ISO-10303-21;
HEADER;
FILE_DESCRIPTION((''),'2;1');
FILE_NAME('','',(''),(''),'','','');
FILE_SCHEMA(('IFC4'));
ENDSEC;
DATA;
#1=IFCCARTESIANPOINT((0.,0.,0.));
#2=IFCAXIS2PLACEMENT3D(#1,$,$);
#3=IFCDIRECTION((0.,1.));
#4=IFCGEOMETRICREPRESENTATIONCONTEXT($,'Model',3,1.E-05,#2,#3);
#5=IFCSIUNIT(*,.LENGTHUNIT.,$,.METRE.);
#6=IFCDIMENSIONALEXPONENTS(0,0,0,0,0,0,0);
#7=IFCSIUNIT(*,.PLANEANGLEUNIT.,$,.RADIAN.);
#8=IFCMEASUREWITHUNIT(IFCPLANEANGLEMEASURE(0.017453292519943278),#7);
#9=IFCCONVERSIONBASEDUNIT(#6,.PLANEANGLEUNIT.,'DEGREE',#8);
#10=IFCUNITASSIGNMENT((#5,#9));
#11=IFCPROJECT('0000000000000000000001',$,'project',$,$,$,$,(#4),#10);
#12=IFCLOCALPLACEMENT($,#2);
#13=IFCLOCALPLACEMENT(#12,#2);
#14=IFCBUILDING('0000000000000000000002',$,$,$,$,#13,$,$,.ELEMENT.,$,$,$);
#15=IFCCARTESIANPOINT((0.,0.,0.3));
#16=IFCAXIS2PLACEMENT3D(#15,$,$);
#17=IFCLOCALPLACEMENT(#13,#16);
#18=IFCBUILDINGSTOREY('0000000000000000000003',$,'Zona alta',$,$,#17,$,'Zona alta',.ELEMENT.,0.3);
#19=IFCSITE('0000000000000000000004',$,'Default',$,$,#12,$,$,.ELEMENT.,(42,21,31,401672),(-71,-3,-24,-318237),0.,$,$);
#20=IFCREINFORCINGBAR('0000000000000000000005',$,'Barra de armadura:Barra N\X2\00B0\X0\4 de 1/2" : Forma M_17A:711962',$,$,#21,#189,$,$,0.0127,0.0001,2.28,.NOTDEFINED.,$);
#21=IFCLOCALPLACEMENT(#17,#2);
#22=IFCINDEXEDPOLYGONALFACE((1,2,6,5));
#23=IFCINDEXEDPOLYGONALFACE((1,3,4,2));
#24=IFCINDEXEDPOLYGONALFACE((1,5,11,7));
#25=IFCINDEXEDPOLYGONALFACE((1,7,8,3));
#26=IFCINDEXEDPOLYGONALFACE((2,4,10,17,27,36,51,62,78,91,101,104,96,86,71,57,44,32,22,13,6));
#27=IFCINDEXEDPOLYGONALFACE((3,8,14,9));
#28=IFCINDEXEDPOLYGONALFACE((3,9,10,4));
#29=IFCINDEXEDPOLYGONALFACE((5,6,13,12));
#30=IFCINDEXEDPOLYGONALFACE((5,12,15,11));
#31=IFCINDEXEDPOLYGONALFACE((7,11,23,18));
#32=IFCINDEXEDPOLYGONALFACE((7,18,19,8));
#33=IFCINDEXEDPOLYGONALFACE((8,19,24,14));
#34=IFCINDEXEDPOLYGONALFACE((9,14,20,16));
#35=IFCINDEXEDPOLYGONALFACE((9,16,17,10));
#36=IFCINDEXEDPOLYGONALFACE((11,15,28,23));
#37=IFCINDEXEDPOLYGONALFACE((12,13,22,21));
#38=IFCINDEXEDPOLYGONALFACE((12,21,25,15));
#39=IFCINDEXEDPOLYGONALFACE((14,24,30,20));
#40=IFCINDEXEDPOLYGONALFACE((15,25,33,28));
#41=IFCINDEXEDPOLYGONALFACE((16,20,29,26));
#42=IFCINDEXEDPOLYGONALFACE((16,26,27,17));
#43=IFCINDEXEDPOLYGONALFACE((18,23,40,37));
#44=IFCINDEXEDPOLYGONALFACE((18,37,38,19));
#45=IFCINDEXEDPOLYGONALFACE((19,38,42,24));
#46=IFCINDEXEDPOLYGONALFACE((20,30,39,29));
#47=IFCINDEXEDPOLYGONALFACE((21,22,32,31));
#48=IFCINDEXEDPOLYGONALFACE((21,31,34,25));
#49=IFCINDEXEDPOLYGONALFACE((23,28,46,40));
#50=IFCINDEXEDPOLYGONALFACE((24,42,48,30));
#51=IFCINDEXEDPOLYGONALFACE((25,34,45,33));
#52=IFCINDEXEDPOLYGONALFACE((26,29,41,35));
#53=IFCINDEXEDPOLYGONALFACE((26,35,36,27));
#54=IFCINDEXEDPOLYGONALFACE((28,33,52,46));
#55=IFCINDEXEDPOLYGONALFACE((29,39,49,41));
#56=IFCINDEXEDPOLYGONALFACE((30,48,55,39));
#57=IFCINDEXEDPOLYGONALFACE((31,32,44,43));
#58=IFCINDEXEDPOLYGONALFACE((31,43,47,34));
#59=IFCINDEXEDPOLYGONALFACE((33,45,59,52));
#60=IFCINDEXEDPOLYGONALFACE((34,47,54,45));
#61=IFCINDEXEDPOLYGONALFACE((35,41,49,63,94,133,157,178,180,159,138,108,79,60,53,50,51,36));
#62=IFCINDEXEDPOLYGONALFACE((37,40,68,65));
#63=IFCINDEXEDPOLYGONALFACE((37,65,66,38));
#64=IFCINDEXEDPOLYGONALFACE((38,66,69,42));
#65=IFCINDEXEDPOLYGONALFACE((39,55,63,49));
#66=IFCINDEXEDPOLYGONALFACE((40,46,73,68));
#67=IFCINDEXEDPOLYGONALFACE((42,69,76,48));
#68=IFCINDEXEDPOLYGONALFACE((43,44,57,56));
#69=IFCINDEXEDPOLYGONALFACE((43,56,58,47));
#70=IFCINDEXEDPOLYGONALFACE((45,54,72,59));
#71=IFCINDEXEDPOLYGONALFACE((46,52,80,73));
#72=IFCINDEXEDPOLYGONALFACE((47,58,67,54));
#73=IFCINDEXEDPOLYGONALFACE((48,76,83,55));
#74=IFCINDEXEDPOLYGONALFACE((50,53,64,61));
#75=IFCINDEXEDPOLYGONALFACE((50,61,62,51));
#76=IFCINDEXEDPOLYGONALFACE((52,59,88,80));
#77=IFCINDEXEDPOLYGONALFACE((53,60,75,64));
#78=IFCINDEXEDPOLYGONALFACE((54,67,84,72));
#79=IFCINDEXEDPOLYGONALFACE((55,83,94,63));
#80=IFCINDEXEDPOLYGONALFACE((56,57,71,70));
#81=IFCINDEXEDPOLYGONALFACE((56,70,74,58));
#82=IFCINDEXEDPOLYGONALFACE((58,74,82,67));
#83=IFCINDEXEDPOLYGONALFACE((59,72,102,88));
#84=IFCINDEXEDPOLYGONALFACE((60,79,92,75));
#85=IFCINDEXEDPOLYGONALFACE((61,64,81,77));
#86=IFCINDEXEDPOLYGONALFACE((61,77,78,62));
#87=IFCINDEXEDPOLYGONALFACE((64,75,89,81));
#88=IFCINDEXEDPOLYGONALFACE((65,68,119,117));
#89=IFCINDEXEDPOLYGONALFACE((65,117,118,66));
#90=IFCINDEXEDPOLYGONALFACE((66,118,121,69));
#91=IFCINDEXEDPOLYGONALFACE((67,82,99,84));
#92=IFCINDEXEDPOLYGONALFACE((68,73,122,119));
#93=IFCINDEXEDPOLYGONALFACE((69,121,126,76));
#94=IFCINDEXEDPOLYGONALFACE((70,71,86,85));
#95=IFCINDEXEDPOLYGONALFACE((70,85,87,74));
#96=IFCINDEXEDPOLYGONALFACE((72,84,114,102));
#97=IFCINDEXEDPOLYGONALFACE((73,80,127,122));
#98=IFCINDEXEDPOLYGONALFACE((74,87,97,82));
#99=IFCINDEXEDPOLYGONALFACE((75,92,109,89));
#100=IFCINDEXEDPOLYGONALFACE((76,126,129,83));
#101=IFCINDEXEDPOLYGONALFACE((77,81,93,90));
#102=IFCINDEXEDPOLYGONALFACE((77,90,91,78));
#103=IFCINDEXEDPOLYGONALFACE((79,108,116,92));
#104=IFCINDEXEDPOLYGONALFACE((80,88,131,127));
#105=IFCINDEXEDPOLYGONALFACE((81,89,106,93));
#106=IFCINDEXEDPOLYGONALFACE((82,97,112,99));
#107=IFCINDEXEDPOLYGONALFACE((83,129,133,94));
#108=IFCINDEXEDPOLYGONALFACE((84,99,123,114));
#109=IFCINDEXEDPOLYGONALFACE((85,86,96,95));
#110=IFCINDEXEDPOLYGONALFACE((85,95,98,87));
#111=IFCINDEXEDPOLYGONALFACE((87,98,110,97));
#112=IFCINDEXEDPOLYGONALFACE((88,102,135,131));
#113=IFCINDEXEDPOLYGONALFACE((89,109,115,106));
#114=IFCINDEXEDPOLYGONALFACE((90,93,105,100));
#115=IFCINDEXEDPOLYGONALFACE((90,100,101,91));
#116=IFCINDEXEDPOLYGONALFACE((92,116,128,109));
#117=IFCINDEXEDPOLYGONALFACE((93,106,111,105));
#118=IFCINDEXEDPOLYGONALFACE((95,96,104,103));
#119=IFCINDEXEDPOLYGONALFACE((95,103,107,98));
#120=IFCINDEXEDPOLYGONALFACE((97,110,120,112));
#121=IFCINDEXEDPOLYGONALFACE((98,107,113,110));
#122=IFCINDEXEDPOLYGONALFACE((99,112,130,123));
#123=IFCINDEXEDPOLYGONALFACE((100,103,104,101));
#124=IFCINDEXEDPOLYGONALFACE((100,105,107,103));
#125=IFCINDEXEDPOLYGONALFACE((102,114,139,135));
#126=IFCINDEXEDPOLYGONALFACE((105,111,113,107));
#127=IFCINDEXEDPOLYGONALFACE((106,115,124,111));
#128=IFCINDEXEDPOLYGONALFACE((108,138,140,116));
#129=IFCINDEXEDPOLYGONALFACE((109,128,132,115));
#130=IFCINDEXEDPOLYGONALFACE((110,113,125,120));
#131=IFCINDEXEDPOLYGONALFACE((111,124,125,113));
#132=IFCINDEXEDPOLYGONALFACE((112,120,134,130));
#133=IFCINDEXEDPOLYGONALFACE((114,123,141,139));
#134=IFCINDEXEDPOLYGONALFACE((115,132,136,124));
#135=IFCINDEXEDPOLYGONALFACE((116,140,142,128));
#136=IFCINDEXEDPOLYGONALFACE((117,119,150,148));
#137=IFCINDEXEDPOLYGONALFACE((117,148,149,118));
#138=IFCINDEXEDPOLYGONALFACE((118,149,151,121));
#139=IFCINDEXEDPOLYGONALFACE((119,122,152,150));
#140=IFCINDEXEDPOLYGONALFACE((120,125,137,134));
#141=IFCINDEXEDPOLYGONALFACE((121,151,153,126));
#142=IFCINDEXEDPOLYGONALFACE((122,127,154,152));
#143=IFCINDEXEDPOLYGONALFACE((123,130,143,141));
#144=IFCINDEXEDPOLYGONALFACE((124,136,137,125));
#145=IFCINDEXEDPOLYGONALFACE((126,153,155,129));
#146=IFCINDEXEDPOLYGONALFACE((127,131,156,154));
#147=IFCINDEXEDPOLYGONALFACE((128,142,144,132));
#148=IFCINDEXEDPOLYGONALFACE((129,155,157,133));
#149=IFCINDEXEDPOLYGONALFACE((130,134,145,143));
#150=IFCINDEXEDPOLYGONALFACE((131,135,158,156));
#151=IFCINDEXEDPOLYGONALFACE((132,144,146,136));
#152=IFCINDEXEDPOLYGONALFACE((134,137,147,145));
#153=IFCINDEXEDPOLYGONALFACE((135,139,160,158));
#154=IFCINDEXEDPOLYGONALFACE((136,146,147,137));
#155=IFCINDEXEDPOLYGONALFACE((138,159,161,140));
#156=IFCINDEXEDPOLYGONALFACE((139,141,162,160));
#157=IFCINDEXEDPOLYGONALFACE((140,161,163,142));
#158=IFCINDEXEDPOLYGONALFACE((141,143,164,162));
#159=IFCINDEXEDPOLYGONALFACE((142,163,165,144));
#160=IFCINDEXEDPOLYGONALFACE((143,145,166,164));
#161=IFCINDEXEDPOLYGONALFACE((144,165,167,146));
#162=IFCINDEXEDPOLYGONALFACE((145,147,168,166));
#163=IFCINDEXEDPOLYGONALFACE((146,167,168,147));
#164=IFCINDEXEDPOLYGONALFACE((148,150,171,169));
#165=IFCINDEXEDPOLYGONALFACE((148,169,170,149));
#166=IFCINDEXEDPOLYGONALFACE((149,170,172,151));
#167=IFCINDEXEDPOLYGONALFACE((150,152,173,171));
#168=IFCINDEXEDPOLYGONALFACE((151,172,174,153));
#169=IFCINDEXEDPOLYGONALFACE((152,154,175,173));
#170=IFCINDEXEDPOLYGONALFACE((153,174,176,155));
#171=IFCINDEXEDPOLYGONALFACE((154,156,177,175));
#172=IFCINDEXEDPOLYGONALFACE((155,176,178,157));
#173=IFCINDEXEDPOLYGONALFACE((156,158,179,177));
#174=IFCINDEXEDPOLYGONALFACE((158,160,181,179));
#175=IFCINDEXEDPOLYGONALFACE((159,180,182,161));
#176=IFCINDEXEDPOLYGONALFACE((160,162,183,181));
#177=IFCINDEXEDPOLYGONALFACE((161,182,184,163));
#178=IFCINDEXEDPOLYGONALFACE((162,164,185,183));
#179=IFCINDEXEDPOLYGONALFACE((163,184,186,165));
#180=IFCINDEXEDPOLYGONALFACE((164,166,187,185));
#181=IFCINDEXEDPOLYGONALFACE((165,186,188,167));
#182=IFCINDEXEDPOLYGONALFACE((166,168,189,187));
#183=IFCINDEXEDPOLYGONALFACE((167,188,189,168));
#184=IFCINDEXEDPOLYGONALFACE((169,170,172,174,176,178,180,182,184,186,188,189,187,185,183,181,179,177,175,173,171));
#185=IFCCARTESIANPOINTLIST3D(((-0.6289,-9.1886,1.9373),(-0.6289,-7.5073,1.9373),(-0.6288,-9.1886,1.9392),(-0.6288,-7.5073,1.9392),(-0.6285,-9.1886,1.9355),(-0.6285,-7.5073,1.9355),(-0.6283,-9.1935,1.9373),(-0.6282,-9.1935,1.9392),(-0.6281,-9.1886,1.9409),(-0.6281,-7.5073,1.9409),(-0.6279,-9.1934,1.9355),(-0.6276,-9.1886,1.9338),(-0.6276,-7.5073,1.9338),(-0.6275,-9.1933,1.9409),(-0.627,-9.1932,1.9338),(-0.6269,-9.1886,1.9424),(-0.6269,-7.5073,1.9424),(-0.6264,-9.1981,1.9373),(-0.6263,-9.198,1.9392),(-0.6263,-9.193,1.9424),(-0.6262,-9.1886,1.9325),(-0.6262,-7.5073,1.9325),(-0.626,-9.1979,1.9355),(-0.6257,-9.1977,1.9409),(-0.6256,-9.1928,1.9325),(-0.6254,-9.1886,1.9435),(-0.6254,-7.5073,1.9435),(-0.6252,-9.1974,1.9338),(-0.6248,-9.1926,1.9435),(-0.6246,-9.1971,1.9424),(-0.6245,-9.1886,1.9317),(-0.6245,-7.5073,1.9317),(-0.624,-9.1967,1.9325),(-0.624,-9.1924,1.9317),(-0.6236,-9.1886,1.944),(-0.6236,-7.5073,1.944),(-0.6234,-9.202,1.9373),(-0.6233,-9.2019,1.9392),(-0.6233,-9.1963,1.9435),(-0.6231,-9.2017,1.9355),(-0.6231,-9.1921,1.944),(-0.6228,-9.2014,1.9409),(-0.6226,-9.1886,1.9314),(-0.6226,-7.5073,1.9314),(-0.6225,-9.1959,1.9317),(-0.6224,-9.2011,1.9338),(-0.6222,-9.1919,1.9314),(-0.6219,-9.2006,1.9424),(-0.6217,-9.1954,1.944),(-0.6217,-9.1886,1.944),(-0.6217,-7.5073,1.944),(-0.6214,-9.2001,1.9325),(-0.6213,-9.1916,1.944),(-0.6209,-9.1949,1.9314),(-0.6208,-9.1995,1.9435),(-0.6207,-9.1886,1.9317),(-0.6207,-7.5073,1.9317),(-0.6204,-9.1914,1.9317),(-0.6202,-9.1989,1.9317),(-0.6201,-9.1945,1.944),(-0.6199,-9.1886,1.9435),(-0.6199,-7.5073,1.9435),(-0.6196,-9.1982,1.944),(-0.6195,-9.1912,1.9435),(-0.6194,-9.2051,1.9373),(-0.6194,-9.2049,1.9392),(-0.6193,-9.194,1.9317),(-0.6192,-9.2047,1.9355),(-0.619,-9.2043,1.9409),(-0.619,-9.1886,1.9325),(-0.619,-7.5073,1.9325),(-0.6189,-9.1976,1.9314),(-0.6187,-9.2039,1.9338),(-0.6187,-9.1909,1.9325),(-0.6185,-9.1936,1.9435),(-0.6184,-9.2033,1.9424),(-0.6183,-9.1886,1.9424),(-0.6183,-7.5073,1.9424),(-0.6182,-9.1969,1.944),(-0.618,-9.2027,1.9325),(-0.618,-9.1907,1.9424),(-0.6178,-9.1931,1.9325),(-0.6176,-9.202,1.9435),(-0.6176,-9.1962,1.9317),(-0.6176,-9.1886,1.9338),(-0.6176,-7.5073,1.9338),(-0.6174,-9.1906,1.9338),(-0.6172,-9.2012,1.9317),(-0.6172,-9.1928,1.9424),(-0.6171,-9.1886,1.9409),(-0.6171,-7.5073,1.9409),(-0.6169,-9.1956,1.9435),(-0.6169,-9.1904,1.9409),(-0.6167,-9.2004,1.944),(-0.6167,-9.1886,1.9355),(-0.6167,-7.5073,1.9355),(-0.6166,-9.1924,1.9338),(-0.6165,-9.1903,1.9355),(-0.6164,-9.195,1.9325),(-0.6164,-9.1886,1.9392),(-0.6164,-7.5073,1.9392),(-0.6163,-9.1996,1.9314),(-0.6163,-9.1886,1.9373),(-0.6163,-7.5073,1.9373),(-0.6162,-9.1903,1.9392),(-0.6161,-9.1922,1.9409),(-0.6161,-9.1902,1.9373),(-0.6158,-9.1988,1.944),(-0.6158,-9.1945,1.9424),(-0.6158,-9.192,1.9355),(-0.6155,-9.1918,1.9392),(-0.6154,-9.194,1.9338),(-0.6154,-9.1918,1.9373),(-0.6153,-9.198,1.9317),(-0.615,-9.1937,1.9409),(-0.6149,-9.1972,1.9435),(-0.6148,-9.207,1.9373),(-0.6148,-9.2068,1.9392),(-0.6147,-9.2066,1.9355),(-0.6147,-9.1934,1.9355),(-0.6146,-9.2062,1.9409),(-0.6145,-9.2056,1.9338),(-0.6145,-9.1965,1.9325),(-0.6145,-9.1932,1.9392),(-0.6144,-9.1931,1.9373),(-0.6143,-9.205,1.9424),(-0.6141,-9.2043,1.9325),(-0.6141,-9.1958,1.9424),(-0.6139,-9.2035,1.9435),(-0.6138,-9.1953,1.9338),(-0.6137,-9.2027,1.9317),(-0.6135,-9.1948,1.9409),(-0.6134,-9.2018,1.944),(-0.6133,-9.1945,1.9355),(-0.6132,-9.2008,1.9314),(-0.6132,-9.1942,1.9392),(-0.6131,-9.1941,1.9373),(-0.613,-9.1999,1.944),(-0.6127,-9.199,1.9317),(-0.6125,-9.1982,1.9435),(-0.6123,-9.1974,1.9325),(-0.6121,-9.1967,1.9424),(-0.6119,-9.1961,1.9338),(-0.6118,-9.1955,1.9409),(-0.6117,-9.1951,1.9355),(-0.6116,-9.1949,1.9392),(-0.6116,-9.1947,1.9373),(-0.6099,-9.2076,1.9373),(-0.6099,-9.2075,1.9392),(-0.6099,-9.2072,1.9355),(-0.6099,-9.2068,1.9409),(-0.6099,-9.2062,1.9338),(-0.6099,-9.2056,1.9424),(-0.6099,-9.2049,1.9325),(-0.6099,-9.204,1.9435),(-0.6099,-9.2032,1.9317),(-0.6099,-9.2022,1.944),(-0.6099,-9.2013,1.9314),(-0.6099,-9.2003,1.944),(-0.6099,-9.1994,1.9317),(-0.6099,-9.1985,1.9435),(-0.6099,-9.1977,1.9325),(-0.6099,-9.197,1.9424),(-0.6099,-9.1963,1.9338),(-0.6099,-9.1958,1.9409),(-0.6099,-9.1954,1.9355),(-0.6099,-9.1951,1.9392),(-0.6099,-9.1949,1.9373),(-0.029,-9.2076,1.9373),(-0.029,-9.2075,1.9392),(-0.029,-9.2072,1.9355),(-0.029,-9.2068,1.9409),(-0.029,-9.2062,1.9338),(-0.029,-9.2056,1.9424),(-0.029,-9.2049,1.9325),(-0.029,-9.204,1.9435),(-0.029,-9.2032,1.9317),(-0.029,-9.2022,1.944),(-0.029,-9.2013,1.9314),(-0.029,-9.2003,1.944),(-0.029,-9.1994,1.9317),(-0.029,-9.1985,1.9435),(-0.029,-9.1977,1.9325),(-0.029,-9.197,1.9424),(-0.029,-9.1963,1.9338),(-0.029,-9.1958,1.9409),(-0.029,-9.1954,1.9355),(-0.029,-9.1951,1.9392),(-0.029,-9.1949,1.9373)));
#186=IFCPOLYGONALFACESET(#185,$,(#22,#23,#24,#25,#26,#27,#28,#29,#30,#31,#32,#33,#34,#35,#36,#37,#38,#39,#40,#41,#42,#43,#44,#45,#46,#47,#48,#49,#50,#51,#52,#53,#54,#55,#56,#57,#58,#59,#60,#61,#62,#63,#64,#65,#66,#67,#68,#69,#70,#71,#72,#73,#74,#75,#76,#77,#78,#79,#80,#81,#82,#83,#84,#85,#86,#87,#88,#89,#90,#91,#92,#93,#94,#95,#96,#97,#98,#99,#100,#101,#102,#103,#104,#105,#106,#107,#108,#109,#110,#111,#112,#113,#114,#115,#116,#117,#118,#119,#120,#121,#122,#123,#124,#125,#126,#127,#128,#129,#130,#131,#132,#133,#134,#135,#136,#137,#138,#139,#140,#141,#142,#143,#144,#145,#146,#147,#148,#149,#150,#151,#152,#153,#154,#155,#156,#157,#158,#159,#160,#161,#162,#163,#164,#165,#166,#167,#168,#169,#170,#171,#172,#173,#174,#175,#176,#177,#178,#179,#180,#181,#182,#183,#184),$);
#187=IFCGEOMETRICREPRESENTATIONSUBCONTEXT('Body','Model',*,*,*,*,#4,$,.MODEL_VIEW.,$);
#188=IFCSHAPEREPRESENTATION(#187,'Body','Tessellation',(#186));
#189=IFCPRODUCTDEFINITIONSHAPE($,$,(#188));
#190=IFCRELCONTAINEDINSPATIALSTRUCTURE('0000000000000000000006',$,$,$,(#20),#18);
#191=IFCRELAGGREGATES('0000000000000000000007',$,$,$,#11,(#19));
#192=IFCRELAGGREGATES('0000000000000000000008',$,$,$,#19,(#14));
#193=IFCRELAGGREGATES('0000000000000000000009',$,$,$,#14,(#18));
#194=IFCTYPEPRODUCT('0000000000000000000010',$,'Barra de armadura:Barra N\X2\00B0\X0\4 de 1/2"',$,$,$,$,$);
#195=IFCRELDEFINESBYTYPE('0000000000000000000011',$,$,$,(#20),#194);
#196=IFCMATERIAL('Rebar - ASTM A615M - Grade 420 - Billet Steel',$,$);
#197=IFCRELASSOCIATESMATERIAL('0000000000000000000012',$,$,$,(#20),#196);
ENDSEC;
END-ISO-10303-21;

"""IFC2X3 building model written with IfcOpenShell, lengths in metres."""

from ifc_helpers import new_model, entity, si_unit, converted_unit, direction, frame, origin, place, context, subcontext, project, spatial, material, type_object, element, save


model = new_model("IFC2X3")

# Units and contexts
model_context = context("Model", 3, precision=1e-05, world=origin(), true_north=direction((0.0, 1.0)))
body_context = subcontext(model_context, "Body", "Model", "MODEL_VIEW")
ifc_project = project(units=[si_unit("LENGTHUNIT", "METRE"), converted_unit("PLANEANGLEUNIT", "DEGREE", entity("IfcPlaneAngleMeasure", 0.017453292519943278), si_unit("PLANEANGLEUNIT", "RADIAN"), dimensions=[0, 0, 0, 0, 0, 0, 0])], contexts=[model_context])

# Site, building, storey
site_placement = place(None, origin())
site = spatial("IfcSite", under=ifc_project, at=site_placement, Name="Default", CompositionType="ELEMENT", RefLatitude=(42, 21, 31, 401672), RefLongitude=(-71, -3, -24, -318237), RefElevation=0.0)
building_placement = place(site_placement, origin())
building = spatial("IfcBuilding", under=site, at=building_placement, CompositionType="ELEMENT")
storey_placement = place(building_placement, frame((0.0, 0.0, 0.3)))
storey = spatial("IfcBuildingStorey", under=building, at=storey_placement, Name="Zona alta", LongName="Zona alta", CompositionType="ELEMENT", Elevation=0.3)

# Reinforcing bar
ifc_material = material(Name="Rebar - ASTM A615M - Grade 420 - Billet Steel")
type_product_1 = type_object("IfcTypeProduct", Name="Barra de armadura:Barra N°4 de 1/2\"")
reinforcing_bar_1_placement = place(storey_placement, origin())
element("IfcReinforcingBar", 1, at=reinforcing_bar_1_placement, inside=storey, type_object=type_product_1, material=ifc_material, Name="Barra de armadura:Barra N°4 de 1/2\" : Forma M_17A:711962", BarLength=2.28, BarRole="NOTDEFINED", CrossSectionArea=0.0001, NominalDiameter=0.0127, context=body_context, shape_type="AdvancedSweptSolid", body=[
    entity("IfcSweptDiskSolid", entity("IfcCompositeCurve", [entity("IfcCompositeCurveSegment", "CONTINUOUS", True, entity("IfcPolyline", [entity("IfcCartesianPoint", [-0.029, -9.2013, 1.9378]), entity("IfcCartesianPoint", [-0.6099, -9.2013, 1.9378])])), entity("IfcCompositeCurveSegment", "CONTINUOUS", True, entity("IfcTrimmedCurve", entity("IfcCircle", entity("IfcAxis2Placement3D", entity("IfcCartesianPoint", [-0.6099, -9.1886, 1.9378]), entity("IfcDirection", [0.0, 0.0, -1.0]), entity("IfcDirection", [-1.0, 0.0, 0.0])), 0.0127), [entity("IfcParameterValue", 270.0)], [entity("IfcParameterValue", 360.0)], True, "PARAMETER")), entity("IfcCompositeCurveSegment", "CONTINUOUS", True, entity("IfcPolyline", [entity("IfcCartesianPoint", [-0.6226, -9.1886, 1.9378]), entity("IfcCartesianPoint", [-0.6226, -7.5073, 1.9378])]))], False), 0.0063, None, 0.0, 92.0),
])

save(model, "model.ifc")
